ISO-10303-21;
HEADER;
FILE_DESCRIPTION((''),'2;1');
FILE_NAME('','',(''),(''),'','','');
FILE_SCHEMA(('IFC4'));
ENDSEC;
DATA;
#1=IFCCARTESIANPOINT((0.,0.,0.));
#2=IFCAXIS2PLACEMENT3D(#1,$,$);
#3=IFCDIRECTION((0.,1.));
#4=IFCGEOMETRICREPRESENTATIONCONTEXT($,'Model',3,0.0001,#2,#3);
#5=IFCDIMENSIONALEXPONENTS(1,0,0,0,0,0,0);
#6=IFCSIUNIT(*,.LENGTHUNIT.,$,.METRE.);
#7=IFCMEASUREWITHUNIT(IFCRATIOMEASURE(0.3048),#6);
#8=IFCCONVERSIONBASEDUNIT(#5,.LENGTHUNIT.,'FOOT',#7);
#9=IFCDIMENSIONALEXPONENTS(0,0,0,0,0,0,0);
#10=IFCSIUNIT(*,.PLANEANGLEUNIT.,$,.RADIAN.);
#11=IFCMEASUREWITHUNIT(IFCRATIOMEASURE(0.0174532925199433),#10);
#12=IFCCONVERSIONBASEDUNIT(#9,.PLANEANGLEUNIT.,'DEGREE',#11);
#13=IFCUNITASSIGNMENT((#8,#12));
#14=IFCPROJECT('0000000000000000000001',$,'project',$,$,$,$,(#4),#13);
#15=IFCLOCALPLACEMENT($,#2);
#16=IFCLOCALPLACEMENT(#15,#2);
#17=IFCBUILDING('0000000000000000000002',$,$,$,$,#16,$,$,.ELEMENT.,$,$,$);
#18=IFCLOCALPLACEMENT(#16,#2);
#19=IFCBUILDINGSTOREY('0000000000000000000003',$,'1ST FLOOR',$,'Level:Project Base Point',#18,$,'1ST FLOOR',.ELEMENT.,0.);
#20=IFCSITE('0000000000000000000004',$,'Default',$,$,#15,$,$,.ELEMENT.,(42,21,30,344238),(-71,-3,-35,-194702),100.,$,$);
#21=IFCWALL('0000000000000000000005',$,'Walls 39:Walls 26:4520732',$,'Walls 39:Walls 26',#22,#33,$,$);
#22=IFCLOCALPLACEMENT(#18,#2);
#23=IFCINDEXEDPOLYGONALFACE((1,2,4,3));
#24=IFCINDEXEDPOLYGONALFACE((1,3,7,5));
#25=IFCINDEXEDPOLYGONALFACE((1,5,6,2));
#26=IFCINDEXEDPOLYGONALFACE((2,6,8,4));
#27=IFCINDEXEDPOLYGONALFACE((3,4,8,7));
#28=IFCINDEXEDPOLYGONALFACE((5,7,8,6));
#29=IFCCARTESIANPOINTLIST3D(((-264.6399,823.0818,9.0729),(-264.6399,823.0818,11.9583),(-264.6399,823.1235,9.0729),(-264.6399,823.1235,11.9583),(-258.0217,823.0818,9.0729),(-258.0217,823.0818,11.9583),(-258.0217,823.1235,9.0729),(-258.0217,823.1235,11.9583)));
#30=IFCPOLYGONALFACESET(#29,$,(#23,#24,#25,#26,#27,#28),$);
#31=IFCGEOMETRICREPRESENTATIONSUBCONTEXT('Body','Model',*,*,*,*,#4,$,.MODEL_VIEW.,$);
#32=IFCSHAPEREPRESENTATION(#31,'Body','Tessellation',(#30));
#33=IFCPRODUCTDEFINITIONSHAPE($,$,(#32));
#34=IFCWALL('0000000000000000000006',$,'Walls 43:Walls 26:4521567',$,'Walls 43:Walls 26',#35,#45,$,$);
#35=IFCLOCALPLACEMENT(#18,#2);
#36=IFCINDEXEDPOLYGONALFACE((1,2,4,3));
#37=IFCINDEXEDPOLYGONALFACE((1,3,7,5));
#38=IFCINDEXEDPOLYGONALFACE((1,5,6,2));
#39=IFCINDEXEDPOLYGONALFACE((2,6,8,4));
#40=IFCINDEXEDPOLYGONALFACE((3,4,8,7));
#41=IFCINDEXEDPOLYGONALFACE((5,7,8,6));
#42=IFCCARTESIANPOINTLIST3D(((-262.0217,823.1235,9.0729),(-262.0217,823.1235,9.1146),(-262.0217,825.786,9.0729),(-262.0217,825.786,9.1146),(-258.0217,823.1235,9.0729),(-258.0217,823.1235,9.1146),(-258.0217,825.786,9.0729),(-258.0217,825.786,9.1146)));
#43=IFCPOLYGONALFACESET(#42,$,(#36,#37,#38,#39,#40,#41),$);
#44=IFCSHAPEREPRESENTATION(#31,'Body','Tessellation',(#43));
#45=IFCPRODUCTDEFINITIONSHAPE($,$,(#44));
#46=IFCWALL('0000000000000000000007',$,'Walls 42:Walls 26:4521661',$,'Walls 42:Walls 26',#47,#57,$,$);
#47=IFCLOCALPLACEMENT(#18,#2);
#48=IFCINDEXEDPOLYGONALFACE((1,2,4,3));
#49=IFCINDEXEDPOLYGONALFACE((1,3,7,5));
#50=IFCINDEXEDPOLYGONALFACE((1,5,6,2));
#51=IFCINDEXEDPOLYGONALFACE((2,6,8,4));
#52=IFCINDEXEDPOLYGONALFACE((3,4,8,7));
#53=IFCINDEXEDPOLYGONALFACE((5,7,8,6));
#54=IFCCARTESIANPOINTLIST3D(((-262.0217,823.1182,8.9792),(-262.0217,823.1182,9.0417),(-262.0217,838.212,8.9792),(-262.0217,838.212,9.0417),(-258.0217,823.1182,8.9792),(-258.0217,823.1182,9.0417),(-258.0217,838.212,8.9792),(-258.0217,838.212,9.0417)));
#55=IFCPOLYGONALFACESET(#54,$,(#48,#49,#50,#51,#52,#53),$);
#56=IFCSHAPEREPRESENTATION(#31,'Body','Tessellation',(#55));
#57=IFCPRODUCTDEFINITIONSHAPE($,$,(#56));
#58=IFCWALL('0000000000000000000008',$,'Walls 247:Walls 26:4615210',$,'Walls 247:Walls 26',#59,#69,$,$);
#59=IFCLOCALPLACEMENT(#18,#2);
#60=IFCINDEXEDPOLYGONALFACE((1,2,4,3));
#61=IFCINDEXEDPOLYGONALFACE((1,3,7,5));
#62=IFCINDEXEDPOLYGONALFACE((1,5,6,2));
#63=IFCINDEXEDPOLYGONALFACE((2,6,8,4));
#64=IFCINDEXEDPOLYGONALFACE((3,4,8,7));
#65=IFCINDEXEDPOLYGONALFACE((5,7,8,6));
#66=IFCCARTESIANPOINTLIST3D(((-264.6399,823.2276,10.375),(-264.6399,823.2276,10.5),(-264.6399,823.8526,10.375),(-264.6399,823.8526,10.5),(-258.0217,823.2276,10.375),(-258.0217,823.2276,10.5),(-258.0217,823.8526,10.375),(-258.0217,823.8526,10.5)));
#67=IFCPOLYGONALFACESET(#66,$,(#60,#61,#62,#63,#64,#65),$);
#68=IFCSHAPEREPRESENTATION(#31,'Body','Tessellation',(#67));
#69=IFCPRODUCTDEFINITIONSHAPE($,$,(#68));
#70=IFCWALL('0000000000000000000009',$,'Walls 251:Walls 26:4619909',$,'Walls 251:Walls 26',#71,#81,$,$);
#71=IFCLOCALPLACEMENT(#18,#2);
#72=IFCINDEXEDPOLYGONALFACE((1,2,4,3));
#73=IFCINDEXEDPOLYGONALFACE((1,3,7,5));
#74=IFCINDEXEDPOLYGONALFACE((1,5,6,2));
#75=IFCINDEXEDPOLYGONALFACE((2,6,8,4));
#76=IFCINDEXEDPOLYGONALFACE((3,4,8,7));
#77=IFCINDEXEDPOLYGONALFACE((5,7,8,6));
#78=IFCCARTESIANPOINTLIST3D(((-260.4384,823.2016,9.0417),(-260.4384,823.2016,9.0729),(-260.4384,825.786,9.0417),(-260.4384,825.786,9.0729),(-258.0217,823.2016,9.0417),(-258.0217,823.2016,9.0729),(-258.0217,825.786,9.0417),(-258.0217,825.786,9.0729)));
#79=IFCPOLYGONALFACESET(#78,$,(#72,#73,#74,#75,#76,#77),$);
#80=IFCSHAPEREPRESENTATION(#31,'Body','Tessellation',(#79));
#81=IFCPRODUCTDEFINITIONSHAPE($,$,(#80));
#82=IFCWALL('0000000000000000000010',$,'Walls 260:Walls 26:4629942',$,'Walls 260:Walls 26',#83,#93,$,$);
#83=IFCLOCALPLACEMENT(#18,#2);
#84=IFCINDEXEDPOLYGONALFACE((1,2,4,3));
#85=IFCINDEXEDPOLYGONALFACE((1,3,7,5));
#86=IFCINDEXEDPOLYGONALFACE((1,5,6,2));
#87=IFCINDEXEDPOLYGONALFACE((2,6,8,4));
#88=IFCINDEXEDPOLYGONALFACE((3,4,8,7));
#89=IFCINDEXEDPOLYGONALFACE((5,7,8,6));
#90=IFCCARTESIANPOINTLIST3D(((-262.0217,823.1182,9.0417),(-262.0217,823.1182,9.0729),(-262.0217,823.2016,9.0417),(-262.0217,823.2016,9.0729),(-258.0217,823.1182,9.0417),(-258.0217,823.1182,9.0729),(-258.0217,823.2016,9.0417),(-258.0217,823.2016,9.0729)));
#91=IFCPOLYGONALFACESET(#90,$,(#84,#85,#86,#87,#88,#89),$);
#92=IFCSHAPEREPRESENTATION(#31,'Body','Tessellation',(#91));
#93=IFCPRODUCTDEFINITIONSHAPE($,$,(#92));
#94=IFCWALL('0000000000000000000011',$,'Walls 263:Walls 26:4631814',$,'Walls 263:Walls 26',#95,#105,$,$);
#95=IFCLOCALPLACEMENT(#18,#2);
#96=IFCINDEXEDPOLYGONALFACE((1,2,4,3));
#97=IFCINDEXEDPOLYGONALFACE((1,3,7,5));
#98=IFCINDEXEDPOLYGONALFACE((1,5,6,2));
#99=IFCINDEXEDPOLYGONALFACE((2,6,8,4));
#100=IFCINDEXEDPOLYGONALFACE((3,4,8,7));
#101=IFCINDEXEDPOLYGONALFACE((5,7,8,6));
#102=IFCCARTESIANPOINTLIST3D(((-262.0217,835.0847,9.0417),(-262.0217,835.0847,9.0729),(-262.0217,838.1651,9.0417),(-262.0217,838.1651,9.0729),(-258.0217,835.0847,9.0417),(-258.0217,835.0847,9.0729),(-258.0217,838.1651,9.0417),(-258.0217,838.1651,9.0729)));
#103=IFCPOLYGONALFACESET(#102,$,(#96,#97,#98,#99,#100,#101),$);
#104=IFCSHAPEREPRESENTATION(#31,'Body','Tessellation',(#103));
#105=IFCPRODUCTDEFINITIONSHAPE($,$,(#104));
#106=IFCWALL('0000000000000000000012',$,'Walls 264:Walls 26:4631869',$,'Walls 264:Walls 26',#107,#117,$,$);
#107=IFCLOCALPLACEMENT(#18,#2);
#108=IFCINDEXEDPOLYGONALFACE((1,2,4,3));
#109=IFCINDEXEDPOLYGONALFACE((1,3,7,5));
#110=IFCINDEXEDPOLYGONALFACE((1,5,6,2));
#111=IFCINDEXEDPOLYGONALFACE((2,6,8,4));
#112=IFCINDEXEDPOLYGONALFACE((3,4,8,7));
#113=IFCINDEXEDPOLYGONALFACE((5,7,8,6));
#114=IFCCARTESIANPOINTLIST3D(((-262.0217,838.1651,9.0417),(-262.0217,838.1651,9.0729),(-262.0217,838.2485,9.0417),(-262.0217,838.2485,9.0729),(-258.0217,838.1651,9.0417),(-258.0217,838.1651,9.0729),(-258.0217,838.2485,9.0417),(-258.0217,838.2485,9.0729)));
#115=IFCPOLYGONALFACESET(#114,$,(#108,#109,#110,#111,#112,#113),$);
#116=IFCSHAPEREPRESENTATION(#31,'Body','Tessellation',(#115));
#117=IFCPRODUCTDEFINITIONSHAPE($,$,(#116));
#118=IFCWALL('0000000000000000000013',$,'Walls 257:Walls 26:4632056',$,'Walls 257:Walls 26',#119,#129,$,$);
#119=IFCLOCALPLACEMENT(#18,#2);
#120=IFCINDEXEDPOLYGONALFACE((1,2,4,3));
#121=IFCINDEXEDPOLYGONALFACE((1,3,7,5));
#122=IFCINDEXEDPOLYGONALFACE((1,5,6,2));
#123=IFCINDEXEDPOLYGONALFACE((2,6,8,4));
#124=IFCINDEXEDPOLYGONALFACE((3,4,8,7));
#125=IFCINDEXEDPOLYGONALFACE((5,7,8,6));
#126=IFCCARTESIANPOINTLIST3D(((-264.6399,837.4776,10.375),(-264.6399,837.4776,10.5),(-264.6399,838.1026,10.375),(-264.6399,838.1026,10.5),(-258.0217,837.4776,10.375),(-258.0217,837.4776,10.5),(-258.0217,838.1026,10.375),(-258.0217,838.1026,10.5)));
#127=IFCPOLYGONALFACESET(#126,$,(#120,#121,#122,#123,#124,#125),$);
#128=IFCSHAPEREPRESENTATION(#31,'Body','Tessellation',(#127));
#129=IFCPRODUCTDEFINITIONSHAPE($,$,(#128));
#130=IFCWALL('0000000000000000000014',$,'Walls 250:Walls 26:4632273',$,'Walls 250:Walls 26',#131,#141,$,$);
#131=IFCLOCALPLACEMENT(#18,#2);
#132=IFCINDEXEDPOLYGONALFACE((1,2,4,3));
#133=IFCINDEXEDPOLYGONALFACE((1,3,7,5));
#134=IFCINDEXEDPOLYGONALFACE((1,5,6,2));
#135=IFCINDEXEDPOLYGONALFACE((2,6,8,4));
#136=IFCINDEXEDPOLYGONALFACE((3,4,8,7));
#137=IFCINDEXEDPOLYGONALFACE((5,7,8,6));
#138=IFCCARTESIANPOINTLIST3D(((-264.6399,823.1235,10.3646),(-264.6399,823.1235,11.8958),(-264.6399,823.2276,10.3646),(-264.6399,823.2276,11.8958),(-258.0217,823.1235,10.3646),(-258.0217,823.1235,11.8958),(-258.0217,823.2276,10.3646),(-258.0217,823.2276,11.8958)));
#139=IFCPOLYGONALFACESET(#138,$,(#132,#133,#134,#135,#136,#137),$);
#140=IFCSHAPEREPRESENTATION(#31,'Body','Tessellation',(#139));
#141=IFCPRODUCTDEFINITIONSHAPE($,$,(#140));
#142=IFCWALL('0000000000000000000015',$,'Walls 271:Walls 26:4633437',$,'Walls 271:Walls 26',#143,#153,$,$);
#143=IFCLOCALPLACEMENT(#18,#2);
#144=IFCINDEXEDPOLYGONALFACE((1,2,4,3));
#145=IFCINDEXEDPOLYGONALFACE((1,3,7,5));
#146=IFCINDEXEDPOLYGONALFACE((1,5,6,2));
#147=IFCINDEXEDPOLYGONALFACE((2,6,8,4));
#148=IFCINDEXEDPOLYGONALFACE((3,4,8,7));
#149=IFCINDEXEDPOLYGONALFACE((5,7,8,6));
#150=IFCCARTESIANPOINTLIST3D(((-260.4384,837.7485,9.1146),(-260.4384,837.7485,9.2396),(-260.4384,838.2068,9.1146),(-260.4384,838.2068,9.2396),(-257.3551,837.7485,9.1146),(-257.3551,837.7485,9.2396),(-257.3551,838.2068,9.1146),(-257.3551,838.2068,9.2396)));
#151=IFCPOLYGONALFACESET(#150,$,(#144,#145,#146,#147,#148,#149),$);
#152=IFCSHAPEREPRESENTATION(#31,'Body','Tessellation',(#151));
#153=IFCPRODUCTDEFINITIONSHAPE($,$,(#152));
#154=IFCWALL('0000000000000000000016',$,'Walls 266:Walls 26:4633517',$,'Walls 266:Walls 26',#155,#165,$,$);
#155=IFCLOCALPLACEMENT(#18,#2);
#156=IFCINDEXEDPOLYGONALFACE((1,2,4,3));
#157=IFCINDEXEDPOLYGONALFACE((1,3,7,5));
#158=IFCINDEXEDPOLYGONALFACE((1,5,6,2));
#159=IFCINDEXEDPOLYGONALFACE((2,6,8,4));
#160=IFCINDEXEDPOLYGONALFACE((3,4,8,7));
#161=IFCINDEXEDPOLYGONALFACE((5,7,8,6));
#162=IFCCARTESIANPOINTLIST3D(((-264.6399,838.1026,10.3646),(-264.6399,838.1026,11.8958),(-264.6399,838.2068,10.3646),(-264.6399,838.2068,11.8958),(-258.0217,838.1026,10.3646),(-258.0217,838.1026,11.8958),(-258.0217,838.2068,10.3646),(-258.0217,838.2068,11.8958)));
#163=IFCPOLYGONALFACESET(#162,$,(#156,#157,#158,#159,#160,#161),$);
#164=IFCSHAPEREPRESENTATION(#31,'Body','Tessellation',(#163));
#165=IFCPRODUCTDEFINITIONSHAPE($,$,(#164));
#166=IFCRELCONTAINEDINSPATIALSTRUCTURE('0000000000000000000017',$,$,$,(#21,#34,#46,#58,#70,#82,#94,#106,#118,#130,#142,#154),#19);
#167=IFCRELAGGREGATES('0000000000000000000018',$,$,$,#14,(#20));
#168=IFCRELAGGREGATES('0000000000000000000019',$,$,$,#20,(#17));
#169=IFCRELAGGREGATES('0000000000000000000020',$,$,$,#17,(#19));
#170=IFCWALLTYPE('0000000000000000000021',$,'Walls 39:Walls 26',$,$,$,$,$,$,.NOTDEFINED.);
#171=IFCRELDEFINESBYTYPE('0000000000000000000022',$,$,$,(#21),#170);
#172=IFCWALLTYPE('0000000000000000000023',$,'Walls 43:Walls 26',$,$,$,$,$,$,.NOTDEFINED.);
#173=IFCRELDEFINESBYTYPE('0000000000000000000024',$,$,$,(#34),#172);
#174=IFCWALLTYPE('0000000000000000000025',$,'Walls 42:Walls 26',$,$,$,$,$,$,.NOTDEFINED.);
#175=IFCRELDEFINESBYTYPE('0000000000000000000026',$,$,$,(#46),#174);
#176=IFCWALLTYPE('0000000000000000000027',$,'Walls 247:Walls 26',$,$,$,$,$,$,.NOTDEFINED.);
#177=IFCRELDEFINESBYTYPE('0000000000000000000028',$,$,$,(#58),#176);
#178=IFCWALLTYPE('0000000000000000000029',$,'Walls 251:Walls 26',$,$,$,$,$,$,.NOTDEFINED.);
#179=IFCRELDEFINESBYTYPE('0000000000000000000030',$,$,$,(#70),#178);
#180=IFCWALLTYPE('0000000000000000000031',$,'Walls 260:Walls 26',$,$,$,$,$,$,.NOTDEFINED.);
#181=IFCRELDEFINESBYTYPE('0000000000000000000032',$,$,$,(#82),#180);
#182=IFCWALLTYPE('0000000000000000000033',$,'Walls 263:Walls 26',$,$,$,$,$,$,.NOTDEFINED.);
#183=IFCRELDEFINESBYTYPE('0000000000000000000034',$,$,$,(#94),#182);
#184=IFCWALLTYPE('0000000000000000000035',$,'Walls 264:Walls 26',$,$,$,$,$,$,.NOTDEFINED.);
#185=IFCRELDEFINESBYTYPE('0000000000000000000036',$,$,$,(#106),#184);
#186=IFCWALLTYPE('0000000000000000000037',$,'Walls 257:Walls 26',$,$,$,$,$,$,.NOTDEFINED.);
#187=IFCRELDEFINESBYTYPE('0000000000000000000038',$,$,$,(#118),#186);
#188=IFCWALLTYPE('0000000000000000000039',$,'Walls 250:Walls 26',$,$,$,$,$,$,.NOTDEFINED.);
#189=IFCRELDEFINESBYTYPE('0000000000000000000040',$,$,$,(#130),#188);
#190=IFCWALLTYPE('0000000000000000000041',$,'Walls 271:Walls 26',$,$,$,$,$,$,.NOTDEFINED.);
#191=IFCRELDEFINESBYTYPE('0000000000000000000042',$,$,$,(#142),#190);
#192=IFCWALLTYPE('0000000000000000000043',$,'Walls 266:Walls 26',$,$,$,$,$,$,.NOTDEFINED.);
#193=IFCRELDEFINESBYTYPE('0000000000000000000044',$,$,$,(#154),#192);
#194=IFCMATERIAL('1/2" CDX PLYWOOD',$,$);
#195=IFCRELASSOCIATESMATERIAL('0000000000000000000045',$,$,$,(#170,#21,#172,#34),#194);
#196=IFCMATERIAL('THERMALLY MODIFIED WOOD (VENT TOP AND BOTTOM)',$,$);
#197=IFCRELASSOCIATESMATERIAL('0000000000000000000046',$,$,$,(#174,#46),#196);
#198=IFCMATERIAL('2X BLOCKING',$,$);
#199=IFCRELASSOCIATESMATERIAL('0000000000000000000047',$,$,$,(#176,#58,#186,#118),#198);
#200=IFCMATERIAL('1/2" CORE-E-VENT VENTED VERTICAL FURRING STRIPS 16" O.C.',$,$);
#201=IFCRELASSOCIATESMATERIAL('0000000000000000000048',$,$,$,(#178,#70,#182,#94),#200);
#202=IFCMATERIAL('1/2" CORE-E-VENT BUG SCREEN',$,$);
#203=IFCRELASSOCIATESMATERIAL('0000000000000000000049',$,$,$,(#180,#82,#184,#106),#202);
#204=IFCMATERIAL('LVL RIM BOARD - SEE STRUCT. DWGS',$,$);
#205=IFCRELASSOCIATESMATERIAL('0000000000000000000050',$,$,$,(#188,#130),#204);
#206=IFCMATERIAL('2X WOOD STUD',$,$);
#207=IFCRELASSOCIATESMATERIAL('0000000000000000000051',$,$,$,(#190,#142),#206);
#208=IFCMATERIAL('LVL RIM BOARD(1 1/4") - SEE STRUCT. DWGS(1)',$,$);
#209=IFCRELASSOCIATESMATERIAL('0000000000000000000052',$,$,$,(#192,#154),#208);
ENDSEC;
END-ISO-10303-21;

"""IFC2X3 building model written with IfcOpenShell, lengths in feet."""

from ifc_helpers import new_model, entity, si_unit, converted_unit, direction, frame, frame_2d, origin, origin_2d_with_axis, place, context, subcontext, project, spatial, rectangle, extrude, material, type_object, element, save


model = new_model("IFC2X3")

# Units and contexts
model_context = context("Model", 3, precision=0.0001, world=origin(), true_north=direction((0.0, 1.0)))
body_context = subcontext(model_context, "Body", "Model", "MODEL_VIEW")
ifc_project = project(units=[converted_unit("LENGTHUNIT", "FOOT", entity("IfcRatioMeasure", 0.3048), si_unit("LENGTHUNIT", "METRE"), dimensions=[1, 0, 0, 0, 0, 0, 0]), converted_unit("PLANEANGLEUNIT", "DEGREE", entity("IfcRatioMeasure", 0.0174532925199433), si_unit("PLANEANGLEUNIT", "RADIAN"), dimensions=[0, 0, 0, 0, 0, 0, 0])], contexts=[model_context])

# Site, building, storey
site_placement = place(None, origin())
site = spatial("IfcSite", under=ifc_project, at=site_placement, Name="Default", CompositionType="ELEMENT", RefLatitude=(42, 21, 30, 344238), RefLongitude=(-71, -3, -35, -194702), RefElevation=100.0)
building_placement = place(site_placement, origin())
building = spatial("IfcBuilding", under=site, at=building_placement, CompositionType="ELEMENT")
storey_placement = place(building_placement, origin())
storey = spatial("IfcBuildingStorey", under=building, at=storey_placement, Name="1ST FLOOR", ObjectType="Level:Project Base Point", LongName="1ST FLOOR", CompositionType="ELEMENT", Elevation=0.0)

# Walls
ifc_material_1 = material(Name="1/2\" CDX PLYWOOD")
wall_type_1 = type_object("IfcWallType", Name="Walls 39:Walls 26", PredefinedType="NOTDEFINED", material=ifc_material_1)
wall_1_placement = place(storey_placement, frame((-264.6399, 823.0818, 9.0729)))
element("IfcWall", 1, at=wall_1_placement, inside=storey, type_object=wall_type_1, material=ifc_material_1, Name="Walls 39:Walls 26:4520732", ObjectType="Walls 39:Walls 26", context=body_context, shape_type="SweptSolid", body=[
    extrude(rectangle(XDim=6.6181, YDim=0.0417, at=frame_2d((0.0, 0.0), x_axis=(1.0, 0.0))), frame((3.3091, 0.0208, 0.0), z_axis=(0.0, 0.0, 1.0), x_axis=(-1.0, 0.0, 0.0)), (0.0, 0.0, 1.0), 2.8854),
])
wall_type_2 = type_object("IfcWallType", Name="Walls 43:Walls 26", PredefinedType="NOTDEFINED", material=ifc_material_1)
wall_2_placement = place(storey_placement, frame((-262.0217, 823.1235, 9.0729)))
element("IfcWall", 2, at=wall_2_placement, inside=storey, type_object=wall_type_2, material=ifc_material_1, Name="Walls 43:Walls 26:4521567", ObjectType="Walls 43:Walls 26", context=body_context, shape_type="SweptSolid", body=[
    extrude(rectangle(XDim=4.0, YDim=2.6625, at=frame_2d((0.0, 0.0), x_axis=(1.0, 0.0))), frame((2.0, 1.3313, 0.0), z_axis=(0.0, 0.0, 1.0), x_axis=(-1.0, 0.0, 0.0)), (0.0, 0.0, 1.0), 0.0417),
])
ifc_material_2 = material(Name="THERMALLY MODIFIED WOOD (VENT TOP AND BOTTOM)")
wall_type_3 = type_object("IfcWallType", Name="Walls 42:Walls 26", PredefinedType="NOTDEFINED", material=ifc_material_2)
wall_3_placement = place(storey_placement, frame((-262.0217, 823.1182, 8.9792), z_axis=(0.0, 0.0, 1.0), x_axis=(0.0, 1.0, 0.0)))
element("IfcWall", 3, at=wall_3_placement, inside=storey, type_object=wall_type_3, material=ifc_material_2, Name="Walls 42:Walls 26:4521661", ObjectType="Walls 42:Walls 26", context=body_context, shape_type="SweptSolid", body=[
    extrude(rectangle(XDim=4.0, YDim=15.0938, at=frame_2d((0.0, 0.0), x_axis=(1.0, 0.0))), frame((7.5469, -2.0, 0.0), z_axis=(0.0, 0.0, 1.0), x_axis=(0.0, 1.0, 0.0)), (0.0, 0.0, 1.0), 0.0625),
])
ifc_material_3 = material(Name="2X BLOCKING")
wall_type_4 = type_object("IfcWallType", Name="Walls 247:Walls 26", PredefinedType="NOTDEFINED", material=ifc_material_3)
wall_4_placement = place(storey_placement, frame((-264.6399, 823.2276, 10.375)))
element("IfcWall", 4, at=wall_4_placement, inside=storey, type_object=wall_type_4, material=ifc_material_3, Name="Walls 247:Walls 26:4615210", ObjectType="Walls 247:Walls 26", context=body_context, shape_type="SweptSolid", body=[
    extrude(rectangle(XDim=6.6181, YDim=0.625, at=frame_2d((0.0, 0.0), x_axis=(1.0, 0.0))), frame((3.3091, 0.3125, 0.0), z_axis=(0.0, 0.0, 1.0), x_axis=(-1.0, 0.0, 0.0)), (0.0, 0.0, 1.0), 0.125),
])
ifc_material_4 = material(Name="1/2\" CORE-E-VENT VENTED VERTICAL FURRING STRIPS 16\" O.C.")
wall_type_5 = type_object("IfcWallType", Name="Walls 251:Walls 26", PredefinedType="NOTDEFINED", material=ifc_material_4)
wall_5_placement = place(storey_placement, frame((-260.4384, 823.2016, 9.0417), z_axis=(0.0, 0.0, 1.0), x_axis=(0.0, 1.0, 0.0)))
element("IfcWall", 5, at=wall_5_placement, inside=storey, type_object=wall_type_5, material=ifc_material_4, Name="Walls 251:Walls 26:4619909", ObjectType="Walls 251:Walls 26", context=body_context, shape_type="SweptSolid", body=[
    extrude(rectangle(XDim=2.4167, YDim=2.5844, at=frame_2d((0.0, 0.0), x_axis=(1.0, 0.0))), frame((1.2922, -1.2083, 0.0), z_axis=(0.0, 0.0, 1.0), x_axis=(0.0, 1.0, 0.0)), (0.0, 0.0, 1.0), 0.0313),
])
ifc_material_5 = material(Name="1/2\" CORE-E-VENT BUG SCREEN")
wall_type_6 = type_object("IfcWallType", Name="Walls 260:Walls 26", PredefinedType="NOTDEFINED", material=ifc_material_5)
wall_6_placement = place(storey_placement, frame((-262.0217, 823.1182, 9.0417)))
element("IfcWall", 6, at=wall_6_placement, inside=storey, type_object=wall_type_6, material=ifc_material_5, Name="Walls 260:Walls 26:4629942", ObjectType="Walls 260:Walls 26", context=body_context, shape_type="SweptSolid", body=[
    extrude(rectangle(XDim=4.0, YDim=0.0833, at=origin_2d_with_axis()), frame((2.0, 0.0417, 0.0), z_axis=(0.0, 0.0, 1.0), x_axis=(-1.0, 0.0, 0.0)), (0.0, 0.0, 1.0), 0.0313),
])
wall_type_7 = type_object("IfcWallType", Name="Walls 263:Walls 26", PredefinedType="NOTDEFINED", material=ifc_material_4)
wall_7_placement = place(storey_placement, frame((-262.0217, 835.0847, 9.0417)))
element("IfcWall", 7, at=wall_7_placement, inside=storey, type_object=wall_type_7, material=ifc_material_4, Name="Walls 263:Walls 26:4631814", ObjectType="Walls 263:Walls 26", context=body_context, shape_type="SweptSolid", body=[
    extrude(rectangle(XDim=4.0, YDim=3.0805, at=frame_2d((0.0, 0.0), x_axis=(1.0, 0.0))), frame((2.0, 1.5402, 0.0), z_axis=(0.0, 0.0, 1.0), x_axis=(-1.0, 0.0, 0.0)), (0.0, 0.0, 1.0), 0.0313),
])
wall_type_8 = type_object("IfcWallType", Name="Walls 264:Walls 26", PredefinedType="NOTDEFINED", material=ifc_material_5)
wall_8_placement = place(storey_placement, frame((-262.0217, 838.1651, 9.0417)))
element("IfcWall", 8, at=wall_8_placement, inside=storey, type_object=wall_type_8, material=ifc_material_5, Name="Walls 264:Walls 26:4631869", ObjectType="Walls 264:Walls 26", context=body_context, shape_type="SweptSolid", body=[
    extrude(rectangle(XDim=4.0, YDim=0.0833, at=origin_2d_with_axis()), frame((2.0, 0.0417, 0.0), z_axis=(0.0, 0.0, 1.0), x_axis=(-1.0, 0.0, 0.0)), (0.0, 0.0, 1.0), 0.0313),
])
wall_type_9 = type_object("IfcWallType", Name="Walls 257:Walls 26", PredefinedType="NOTDEFINED", material=ifc_material_3)
wall_9_placement = place(storey_placement, frame((-264.6399, 837.4776, 10.375)))
element("IfcWall", 9, at=wall_9_placement, inside=storey, type_object=wall_type_9, material=ifc_material_3, Name="Walls 257:Walls 26:4632056", ObjectType="Walls 257:Walls 26", context=body_context, shape_type="SweptSolid", body=[
    extrude(rectangle(XDim=6.6181, YDim=0.625, at=frame_2d((0.0, 0.0), x_axis=(1.0, 0.0))), frame((3.3091, 0.3125, 0.0), z_axis=(0.0, 0.0, 1.0), x_axis=(-1.0, 0.0, 0.0)), (0.0, 0.0, 1.0), 0.125),
])
ifc_material_6 = material(Name="LVL RIM BOARD - SEE STRUCT. DWGS")
wall_type_10 = type_object("IfcWallType", Name="Walls 250:Walls 26", PredefinedType="NOTDEFINED", material=ifc_material_6)
wall_10_placement = place(storey_placement, frame((-264.6399, 823.1235, 10.3646)))
element("IfcWall", 10, at=wall_10_placement, inside=storey, type_object=wall_type_10, material=ifc_material_6, Name="Walls 250:Walls 26:4632273", ObjectType="Walls 250:Walls 26", context=body_context, shape_type="SweptSolid", body=[
    extrude(rectangle(XDim=6.6181, YDim=0.1042, at=frame_2d((0.0, 0.0), x_axis=(1.0, 0.0))), frame((3.3091, 0.0521, 0.0), z_axis=(0.0, 0.0, 1.0), x_axis=(-1.0, 0.0, 0.0)), (0.0, 0.0, 1.0), 1.5312),
])
ifc_material_7 = material(Name="2X WOOD STUD")
wall_type_11 = type_object("IfcWallType", Name="Walls 271:Walls 26", PredefinedType="NOTDEFINED", material=ifc_material_7)
wall_11_placement = place(storey_placement, frame((-260.4384, 837.7485, 9.1146)))
element("IfcWall", 11, at=wall_11_placement, inside=storey, type_object=wall_type_11, material=ifc_material_7, Name="Walls 271:Walls 26:4633437", ObjectType="Walls 271:Walls 26", context=body_context, shape_type="SweptSolid", body=[
    extrude(rectangle(XDim=3.0833, YDim=0.4583, at=frame_2d((0.0, 0.0), x_axis=(1.0, 0.0))), frame((1.5417, 0.2292, 0.0), z_axis=(0.0, 0.0, 1.0), x_axis=(-1.0, 0.0, 0.0)), (0.0, 0.0, 1.0), 0.125),
])
ifc_material_8 = material(Name="LVL RIM BOARD(1 1/4\") - SEE STRUCT. DWGS(1)")
wall_type_12 = type_object("IfcWallType", Name="Walls 266:Walls 26", PredefinedType="NOTDEFINED", material=ifc_material_8)
wall_12_placement = place(storey_placement, frame((-264.6399, 838.1026, 10.3646)))
element("IfcWall", 12, at=wall_12_placement, inside=storey, type_object=wall_type_12, material=ifc_material_8, Name="Walls 266:Walls 26:4633517", ObjectType="Walls 266:Walls 26", context=body_context, shape_type="SweptSolid", body=[
    extrude(rectangle(XDim=6.6181, YDim=0.1042, at=frame_2d((0.0, 0.0), x_axis=(1.0, 0.0))), frame((3.3091, 0.0521, 0.0), z_axis=(0.0, 0.0, 1.0), x_axis=(-1.0, 0.0, 0.0)), (0.0, 0.0, 1.0), 1.5312),
])

save(model, "model.ifc")
